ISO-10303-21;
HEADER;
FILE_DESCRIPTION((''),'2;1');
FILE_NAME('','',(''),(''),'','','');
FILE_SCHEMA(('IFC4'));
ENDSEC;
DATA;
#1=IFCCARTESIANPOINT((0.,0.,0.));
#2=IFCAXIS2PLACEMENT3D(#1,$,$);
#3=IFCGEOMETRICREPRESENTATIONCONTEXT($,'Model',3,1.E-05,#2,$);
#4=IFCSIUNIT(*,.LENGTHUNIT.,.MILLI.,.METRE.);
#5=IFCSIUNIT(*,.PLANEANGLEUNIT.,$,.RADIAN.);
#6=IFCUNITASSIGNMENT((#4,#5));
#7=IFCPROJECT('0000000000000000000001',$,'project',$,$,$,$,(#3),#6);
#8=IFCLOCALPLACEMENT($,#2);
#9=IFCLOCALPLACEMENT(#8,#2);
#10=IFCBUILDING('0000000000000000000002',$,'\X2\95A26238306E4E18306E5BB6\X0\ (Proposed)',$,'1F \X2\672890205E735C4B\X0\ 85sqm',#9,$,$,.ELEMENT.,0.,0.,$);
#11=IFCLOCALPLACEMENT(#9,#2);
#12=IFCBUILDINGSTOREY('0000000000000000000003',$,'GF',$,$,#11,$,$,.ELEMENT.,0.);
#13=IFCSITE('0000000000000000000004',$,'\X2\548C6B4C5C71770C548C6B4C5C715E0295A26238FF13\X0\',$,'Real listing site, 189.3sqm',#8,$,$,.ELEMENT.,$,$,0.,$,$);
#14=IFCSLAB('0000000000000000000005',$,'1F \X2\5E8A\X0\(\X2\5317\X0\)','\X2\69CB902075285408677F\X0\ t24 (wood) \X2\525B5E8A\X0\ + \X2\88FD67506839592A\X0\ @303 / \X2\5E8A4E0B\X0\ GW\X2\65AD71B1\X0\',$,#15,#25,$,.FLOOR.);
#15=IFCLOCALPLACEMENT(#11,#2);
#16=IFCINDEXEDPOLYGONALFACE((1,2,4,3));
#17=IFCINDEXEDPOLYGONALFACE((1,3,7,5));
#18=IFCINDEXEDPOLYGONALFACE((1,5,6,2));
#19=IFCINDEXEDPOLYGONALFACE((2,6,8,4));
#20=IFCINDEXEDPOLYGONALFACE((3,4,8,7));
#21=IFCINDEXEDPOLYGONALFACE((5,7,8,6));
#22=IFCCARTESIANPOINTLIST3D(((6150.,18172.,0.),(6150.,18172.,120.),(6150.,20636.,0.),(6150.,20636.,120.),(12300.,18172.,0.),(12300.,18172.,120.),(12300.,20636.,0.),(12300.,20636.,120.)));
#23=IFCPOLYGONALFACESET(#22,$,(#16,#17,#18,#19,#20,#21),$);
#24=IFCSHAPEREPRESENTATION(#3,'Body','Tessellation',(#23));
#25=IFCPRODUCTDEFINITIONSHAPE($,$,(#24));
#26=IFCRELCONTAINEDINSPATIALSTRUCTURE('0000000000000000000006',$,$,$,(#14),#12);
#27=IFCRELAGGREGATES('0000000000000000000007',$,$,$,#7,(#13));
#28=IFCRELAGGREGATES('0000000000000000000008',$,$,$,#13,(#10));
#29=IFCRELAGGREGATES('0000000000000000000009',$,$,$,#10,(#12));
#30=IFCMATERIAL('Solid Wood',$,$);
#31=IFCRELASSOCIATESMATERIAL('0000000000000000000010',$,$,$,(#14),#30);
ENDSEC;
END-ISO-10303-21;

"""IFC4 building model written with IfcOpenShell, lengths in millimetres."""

from ifc_helpers import new_model, si_unit, frame, frame_2d, origin, place, context, project, spatial, rectangle, extrude, material, element, save


model = new_model("IFC4")

# Units and contexts
model_context = context("Model", 3, precision=1e-05, world=origin())
ifc_project = project(units=[si_unit("LENGTHUNIT", "METRE", prefix="MILLI"), si_unit("PLANEANGLEUNIT", "RADIAN")], contexts=[model_context])

# Site, building, storey
site_placement = place(None, origin())
site = spatial("IfcSite", under=ifc_project, at=site_placement, Name="和歌山県和歌山市関戸３", ObjectType="Real listing site, 189.3sqm", CompositionType="ELEMENT", RefElevation=0.0)
building_placement = place(site_placement, origin())
building = spatial("IfcBuilding", under=site, at=building_placement, Name="関戸の丘の家 (Proposed)", ObjectType="1F 木造平屋 85sqm", CompositionType="ELEMENT", ElevationOfRefHeight=0.0, ElevationOfTerrain=0.0)
storey_placement = place(building_placement, origin())
storey = spatial("IfcBuildingStorey", under=building, at=storey_placement, Name="GF", CompositionType="ELEMENT", Elevation=0.0)

# Slab
ifc_material_1 = material(Name="Solid Wood")
slab_1_placement = place(storey_placement, frame((3075.0, 9086.0, 0.0)))
element("IfcSlab", 1, at=slab_1_placement, inside=storey, material=ifc_material_1, Name="1F 床(北)", Description="構造用合板 t24 (wood) 剛床 + 製材根太 @303 / 床下 GW断熱", PredefinedType="FLOOR", context=model_context, shape_type="SweptSolid", body=[
    extrude(rectangle(XDim=6150.0, YDim=2464.0, at=frame_2d((3075.0, 1232.0))), frame((3075.0, 9086.0, 0.0)), (0.0, 0.0, 1.0), 120.0),
])

save(model, "model.ifc")
